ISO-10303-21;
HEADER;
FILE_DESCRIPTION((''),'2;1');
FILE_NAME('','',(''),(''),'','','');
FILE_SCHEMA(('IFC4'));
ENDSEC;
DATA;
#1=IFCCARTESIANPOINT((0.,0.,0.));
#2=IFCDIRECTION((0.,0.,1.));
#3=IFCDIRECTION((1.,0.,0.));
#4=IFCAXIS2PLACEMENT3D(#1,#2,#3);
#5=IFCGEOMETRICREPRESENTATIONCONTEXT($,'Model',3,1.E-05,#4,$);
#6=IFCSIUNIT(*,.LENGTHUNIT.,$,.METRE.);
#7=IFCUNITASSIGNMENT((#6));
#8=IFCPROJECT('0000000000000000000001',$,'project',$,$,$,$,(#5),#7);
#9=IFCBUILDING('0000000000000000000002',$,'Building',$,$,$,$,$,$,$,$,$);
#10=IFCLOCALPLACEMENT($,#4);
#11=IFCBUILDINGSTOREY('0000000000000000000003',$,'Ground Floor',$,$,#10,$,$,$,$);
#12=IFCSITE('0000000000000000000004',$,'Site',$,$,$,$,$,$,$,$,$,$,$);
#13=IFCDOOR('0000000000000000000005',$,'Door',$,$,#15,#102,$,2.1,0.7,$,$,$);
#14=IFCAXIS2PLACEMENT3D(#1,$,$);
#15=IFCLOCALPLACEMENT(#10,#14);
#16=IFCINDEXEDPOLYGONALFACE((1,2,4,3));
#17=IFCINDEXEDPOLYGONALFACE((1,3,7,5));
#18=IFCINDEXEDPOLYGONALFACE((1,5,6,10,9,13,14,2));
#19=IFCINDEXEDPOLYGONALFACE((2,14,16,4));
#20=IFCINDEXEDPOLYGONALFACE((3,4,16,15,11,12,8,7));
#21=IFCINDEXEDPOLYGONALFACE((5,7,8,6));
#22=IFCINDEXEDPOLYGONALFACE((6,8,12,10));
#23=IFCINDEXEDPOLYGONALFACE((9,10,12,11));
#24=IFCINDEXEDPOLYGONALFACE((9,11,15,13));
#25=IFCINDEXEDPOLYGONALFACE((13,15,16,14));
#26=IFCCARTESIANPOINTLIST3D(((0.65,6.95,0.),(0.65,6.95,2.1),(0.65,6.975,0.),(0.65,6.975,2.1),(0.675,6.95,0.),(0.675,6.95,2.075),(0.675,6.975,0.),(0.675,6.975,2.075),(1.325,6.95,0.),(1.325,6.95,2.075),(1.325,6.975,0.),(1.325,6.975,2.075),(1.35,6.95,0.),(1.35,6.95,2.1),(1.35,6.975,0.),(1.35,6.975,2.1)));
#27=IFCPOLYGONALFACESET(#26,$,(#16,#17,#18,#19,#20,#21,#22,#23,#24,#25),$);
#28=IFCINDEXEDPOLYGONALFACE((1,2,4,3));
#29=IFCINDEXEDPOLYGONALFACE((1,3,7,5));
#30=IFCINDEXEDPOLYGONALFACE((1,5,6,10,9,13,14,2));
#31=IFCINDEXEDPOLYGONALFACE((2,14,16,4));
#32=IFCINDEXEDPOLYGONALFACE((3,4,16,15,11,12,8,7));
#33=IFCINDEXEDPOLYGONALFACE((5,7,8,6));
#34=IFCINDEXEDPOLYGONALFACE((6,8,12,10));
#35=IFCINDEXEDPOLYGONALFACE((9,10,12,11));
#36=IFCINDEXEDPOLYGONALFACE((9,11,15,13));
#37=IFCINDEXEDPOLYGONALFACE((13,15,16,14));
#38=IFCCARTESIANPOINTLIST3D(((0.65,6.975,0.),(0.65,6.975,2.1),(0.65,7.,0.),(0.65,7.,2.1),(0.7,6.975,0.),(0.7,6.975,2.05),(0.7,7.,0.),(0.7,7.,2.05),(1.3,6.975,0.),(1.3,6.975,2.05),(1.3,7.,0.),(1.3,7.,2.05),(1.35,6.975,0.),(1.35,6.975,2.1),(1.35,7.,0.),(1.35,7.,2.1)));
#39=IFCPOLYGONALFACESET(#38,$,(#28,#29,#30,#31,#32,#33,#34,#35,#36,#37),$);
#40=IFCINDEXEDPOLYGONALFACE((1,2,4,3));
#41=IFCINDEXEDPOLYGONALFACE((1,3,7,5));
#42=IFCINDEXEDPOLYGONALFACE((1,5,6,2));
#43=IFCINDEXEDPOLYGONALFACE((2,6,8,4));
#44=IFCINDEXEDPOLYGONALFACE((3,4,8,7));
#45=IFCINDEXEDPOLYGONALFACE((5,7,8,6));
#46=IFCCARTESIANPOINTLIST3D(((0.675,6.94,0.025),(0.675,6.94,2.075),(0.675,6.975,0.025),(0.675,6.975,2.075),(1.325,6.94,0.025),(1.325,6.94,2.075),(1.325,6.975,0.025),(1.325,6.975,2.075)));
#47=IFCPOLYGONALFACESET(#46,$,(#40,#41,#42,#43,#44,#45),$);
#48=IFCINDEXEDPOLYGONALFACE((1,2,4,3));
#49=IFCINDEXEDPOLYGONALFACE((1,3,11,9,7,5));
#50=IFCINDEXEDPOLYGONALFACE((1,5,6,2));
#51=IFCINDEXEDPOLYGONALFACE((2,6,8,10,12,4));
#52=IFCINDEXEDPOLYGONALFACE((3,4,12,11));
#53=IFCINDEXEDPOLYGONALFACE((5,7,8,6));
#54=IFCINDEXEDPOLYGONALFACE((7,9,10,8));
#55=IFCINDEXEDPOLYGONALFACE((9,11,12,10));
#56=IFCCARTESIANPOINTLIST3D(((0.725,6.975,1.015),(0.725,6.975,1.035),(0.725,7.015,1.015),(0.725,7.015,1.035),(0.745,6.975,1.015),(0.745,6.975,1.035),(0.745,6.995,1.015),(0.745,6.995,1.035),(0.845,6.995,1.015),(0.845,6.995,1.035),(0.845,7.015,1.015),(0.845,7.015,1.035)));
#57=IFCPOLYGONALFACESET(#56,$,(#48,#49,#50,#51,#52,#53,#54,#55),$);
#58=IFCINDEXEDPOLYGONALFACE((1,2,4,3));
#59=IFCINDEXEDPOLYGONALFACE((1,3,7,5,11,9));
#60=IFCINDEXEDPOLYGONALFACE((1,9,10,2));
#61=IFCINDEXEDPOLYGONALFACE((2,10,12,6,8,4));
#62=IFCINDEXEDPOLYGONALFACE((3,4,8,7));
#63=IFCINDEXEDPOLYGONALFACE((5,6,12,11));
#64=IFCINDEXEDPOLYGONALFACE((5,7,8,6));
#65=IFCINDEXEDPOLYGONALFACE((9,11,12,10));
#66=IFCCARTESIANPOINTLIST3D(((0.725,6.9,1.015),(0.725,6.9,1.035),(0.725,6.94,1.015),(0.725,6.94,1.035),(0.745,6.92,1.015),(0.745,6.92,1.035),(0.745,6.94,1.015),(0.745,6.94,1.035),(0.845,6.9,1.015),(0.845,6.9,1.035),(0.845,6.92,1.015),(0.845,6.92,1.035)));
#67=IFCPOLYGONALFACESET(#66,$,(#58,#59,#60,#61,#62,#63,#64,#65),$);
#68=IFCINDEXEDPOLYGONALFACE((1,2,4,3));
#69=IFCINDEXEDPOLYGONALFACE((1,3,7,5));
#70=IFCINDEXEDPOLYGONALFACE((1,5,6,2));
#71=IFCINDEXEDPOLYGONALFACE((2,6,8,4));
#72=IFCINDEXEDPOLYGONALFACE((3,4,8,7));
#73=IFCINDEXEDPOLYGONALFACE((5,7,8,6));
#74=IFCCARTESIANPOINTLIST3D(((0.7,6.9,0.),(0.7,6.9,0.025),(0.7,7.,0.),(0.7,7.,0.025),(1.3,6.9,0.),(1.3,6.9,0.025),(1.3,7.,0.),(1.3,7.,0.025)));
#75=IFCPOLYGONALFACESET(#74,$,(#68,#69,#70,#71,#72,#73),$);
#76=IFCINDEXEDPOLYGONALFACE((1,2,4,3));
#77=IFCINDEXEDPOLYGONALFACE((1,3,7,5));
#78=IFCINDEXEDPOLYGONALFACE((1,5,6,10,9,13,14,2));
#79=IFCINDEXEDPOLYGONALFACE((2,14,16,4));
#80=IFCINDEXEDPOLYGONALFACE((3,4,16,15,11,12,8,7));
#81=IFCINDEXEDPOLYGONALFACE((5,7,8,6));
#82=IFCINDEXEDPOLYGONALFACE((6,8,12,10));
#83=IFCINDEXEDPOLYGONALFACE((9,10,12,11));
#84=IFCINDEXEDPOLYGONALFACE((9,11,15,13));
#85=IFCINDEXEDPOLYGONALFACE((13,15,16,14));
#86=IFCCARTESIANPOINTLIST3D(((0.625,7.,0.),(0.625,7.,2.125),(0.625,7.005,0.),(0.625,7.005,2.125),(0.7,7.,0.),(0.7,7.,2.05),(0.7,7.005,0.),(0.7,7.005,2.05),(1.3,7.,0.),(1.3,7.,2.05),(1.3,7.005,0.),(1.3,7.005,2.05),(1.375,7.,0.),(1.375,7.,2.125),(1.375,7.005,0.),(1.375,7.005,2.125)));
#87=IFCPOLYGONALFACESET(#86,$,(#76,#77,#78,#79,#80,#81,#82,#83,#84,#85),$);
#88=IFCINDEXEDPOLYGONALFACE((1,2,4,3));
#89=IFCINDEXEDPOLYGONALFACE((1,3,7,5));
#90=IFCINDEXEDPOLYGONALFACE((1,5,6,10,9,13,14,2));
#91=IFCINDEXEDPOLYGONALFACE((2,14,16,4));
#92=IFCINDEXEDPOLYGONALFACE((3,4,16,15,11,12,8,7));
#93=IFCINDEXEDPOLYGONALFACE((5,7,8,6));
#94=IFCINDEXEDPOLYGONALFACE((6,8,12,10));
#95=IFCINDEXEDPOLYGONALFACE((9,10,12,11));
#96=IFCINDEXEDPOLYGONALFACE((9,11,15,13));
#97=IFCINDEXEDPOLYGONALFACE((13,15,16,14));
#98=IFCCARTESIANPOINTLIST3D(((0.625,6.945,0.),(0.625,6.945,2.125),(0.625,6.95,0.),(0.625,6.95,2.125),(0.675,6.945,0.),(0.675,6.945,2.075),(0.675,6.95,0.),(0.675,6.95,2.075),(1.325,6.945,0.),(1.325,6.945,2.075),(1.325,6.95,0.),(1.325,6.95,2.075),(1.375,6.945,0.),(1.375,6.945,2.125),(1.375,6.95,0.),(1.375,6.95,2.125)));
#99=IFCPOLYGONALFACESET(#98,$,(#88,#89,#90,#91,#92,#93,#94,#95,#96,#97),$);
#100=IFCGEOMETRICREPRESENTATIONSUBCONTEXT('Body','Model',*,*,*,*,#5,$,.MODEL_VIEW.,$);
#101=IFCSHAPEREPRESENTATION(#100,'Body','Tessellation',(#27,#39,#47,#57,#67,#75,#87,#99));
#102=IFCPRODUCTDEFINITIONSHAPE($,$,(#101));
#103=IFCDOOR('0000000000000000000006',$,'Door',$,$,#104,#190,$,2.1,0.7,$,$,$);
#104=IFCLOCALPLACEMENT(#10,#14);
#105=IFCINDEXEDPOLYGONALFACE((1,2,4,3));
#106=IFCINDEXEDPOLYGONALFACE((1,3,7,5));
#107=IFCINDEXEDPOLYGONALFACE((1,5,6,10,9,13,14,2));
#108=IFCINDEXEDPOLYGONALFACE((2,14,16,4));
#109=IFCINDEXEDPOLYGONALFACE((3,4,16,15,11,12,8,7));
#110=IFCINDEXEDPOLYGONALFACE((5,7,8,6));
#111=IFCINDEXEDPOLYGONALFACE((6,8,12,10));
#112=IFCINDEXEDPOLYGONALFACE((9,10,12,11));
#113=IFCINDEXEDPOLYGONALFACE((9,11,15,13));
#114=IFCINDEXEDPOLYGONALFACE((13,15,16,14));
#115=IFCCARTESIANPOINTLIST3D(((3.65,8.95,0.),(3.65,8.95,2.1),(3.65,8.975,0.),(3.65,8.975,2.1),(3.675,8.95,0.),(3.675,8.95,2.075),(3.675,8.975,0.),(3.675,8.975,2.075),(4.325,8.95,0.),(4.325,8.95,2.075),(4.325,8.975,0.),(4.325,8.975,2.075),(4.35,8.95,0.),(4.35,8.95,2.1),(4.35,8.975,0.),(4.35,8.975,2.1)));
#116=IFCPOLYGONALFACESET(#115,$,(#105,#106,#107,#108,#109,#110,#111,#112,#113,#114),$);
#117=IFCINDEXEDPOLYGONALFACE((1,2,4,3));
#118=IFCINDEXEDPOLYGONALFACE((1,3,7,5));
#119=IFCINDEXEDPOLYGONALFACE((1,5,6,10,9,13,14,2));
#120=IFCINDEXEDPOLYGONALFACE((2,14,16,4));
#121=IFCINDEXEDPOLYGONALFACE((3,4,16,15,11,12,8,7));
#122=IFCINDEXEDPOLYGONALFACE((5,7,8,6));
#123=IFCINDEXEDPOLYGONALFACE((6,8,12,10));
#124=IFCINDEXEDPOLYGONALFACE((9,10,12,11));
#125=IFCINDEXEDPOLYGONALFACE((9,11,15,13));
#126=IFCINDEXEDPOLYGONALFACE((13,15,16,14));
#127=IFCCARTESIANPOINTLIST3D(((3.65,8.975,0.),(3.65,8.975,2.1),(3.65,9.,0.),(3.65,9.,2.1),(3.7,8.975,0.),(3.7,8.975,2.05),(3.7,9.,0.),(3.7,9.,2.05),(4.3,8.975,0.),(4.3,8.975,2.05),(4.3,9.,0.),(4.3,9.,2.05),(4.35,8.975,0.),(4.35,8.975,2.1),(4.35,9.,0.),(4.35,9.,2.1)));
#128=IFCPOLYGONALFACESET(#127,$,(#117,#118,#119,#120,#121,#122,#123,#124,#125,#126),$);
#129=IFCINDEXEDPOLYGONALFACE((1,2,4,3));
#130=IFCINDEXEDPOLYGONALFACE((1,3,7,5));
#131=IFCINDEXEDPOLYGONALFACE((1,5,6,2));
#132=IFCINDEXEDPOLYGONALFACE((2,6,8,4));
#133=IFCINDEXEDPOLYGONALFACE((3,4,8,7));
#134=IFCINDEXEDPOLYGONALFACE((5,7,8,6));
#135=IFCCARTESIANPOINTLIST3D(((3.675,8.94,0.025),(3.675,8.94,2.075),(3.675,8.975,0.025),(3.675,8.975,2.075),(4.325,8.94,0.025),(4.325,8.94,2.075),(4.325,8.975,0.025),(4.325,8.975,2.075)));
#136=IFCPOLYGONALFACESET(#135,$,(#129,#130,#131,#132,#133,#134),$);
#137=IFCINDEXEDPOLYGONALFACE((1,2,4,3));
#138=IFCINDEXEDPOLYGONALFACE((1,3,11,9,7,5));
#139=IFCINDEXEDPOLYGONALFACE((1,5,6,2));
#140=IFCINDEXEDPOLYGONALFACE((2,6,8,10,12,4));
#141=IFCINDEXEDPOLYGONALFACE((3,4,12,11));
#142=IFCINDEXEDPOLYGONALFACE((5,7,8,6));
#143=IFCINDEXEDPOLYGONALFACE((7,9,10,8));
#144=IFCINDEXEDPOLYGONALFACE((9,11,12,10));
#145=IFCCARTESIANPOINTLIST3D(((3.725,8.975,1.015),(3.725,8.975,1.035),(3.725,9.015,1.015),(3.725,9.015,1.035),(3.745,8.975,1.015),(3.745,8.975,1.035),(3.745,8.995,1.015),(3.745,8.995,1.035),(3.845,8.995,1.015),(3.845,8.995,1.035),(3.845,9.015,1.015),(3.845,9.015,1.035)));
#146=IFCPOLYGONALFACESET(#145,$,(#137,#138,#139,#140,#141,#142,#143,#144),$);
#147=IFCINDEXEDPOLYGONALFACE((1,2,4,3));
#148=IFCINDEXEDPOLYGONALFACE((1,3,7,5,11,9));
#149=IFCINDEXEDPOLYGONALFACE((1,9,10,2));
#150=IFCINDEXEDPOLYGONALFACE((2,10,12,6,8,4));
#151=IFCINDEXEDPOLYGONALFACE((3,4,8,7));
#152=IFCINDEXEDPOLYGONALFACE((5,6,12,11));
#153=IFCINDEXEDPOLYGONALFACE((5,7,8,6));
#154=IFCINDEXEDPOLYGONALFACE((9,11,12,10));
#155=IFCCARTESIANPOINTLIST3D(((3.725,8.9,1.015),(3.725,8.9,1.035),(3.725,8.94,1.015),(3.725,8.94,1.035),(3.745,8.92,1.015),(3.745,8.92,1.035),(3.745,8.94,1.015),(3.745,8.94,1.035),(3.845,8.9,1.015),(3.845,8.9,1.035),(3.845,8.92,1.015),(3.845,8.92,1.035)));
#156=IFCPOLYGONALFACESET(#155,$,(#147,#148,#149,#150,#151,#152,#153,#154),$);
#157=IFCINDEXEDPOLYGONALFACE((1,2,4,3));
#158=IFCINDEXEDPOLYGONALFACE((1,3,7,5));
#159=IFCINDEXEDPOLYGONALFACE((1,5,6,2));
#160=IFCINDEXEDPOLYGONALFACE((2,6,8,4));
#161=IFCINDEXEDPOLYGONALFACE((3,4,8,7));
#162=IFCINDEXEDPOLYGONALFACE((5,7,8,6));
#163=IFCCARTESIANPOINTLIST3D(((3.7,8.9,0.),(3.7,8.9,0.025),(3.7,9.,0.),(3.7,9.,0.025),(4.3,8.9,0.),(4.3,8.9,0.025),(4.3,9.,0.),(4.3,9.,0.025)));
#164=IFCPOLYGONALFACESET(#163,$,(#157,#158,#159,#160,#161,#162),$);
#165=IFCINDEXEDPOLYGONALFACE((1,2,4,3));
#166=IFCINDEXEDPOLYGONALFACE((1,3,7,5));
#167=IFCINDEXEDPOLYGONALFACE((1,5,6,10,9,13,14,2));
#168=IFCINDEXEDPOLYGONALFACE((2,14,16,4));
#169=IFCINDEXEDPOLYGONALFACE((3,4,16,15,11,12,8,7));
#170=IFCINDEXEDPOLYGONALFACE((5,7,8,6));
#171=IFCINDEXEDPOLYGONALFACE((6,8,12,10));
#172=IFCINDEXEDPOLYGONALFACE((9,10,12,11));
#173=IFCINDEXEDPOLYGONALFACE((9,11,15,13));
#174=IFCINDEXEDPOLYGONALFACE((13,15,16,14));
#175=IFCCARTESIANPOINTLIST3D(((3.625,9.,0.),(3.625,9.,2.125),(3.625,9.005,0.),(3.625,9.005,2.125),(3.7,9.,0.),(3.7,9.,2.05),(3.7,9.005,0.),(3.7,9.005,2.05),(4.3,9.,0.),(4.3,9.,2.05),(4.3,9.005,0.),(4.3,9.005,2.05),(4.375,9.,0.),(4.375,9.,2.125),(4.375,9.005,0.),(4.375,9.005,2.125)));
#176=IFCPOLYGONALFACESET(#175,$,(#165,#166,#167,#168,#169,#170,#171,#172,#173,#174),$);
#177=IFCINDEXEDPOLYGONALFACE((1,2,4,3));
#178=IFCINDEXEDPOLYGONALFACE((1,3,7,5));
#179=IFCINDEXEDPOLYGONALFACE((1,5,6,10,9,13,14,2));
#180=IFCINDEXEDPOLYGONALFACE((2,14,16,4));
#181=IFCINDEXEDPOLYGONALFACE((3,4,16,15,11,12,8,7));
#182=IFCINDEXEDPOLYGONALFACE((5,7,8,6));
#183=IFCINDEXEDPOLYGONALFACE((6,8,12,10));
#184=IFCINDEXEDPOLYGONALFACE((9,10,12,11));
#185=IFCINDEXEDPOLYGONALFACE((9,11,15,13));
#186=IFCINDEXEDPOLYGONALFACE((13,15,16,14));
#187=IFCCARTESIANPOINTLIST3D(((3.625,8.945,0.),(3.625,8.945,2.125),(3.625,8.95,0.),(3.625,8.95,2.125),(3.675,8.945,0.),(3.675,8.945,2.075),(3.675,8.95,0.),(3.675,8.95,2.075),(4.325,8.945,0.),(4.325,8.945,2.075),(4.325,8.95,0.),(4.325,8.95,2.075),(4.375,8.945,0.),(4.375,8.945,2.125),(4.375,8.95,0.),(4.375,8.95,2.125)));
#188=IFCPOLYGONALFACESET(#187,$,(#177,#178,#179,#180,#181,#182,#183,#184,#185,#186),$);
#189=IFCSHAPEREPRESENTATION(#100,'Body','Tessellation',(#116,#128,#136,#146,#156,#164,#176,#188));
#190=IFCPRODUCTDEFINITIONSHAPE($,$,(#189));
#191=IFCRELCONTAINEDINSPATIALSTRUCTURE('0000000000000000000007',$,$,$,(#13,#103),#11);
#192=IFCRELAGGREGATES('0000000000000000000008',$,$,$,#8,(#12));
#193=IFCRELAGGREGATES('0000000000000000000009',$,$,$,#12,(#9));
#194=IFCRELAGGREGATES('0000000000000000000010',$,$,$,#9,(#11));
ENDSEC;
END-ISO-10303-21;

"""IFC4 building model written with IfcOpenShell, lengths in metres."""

from ifc_helpers import new_model, si_unit, frame, origin_with_axes, place, context, subcontext, project, spatial, line, indexed_curve, outline, extrude, element, save


model = new_model("IFC4")

# Units and contexts
model_context = context("Model", 3, precision=1e-05, world=origin_with_axes())
body_context = subcontext(model_context, "Body", "Model", "MODEL_VIEW")
ifc_project = project(units=[si_unit("LENGTHUNIT", "METRE")], contexts=[model_context])

# Site, building, storey
site = spatial("IfcSite", under=ifc_project, Name="Site")
building = spatial("IfcBuilding", under=site, Name="Building")
storey_placement = place(None, origin_with_axes())
storey = spatial("IfcBuildingStorey", under=building, at=storey_placement, Name="Ground Floor")

# Doors
door_1_placement = place(storey_placement, frame((1.35, 7.0, 0.0), z_axis=(0.0, 0.0, 1.0), x_axis=(-1.0, 0.0, 0.0)))
element("IfcDoor", 1, at=door_1_placement, inside=storey, Name="Door", OverallHeight=2.1, OverallWidth=0.7, context=body_context, shape_type="SweptSolid", body=[
    extrude(outline(indexed_curve([(0.0, 0.0), (0.0, 2.1), (0.7, 2.1), (0.7, 0.0), (0.675, 0.0), (0.675, 2.075), (0.025, 2.075), (0.025, 0.0)], segments=[line(1, 2, 3, 4, 5, 6, 7, 8, 1)])), frame((0.0, 0.025, 0.0), z_axis=(0.0, -1.0, 0.0), x_axis=(1.0, 0.0, 0.0)), (0.0, 0.0, -1.0), 0.025),
    extrude(outline(indexed_curve([(0.0, 0.0), (0.0, 2.1), (0.7, 2.1), (0.7, 0.0), (0.65, 0.0), (0.65, 2.05), (0.05, 2.05), (0.05, 0.0)], segments=[line(1, 2, 3, 4, 5, 6, 7, 8, 1)])), frame((0.0, 0.0, 0.0), z_axis=(0.0, -1.0, 0.0), x_axis=(1.0, 0.0, 0.0)), (0.0, 0.0, -1.0), 0.025),
    extrude(outline(indexed_curve([(0.0, 0.0), (0.65, 0.0), (0.65, 0.035), (0.0, 0.035)], segments=[line(1, 2, 3, 4, 1)])), frame((0.025, 0.025, 0.025), z_axis=(0.0, 0.0, 1.0), x_axis=(1.0, 0.0, 0.0)), (0.0, 0.0, 1.0), 2.05),
    extrude(outline(indexed_curve([(0.0, 0.0), (0.0, -0.04), (-0.12, -0.04), (-0.12, -0.02), (-0.02, -0.02), (-0.02, 0.0)], segments=[line(1, 2, 3, 4, 5, 6, 1)])), frame((0.625, 0.025, 1.015), z_axis=(0.0, 0.0, 1.0), x_axis=(1.0, 0.0, 0.0)), (0.0, 0.0, 1.0), 0.02),
    extrude(outline(indexed_curve([(0.0, 0.0), (0.0, 0.04), (-0.12, 0.04), (-0.12, 0.02), (-0.02, 0.02), (-0.02, 0.0)], segments=[line(1, 2, 3, 4, 5, 6, 1)])), frame((0.625, 0.06, 1.015), z_axis=(0.0, 0.0, 1.0), x_axis=(1.0, 0.0, 0.0)), (0.0, 0.0, 1.0), 0.02),
    extrude(outline(indexed_curve([(0.0, 0.0), (0.6, 0.0), (0.6, 0.1), (0.0, 0.1)], segments=[line(1, 2, 3, 4, 1)])), frame((0.05, 0.0, 0.0), z_axis=(0.0, 0.0, 1.0), x_axis=(1.0, 0.0, 0.0)), (0.0, 0.0, 1.0), 0.025),
    extrude(outline(indexed_curve([(0.0, 0.0), (0.0, 2.125), (0.75, 2.125), (0.75, 0.0), (0.675, 0.0), (0.675, 2.05), (0.075, 2.05), (0.075, 0.0)], segments=[line(1, 2, 3, 4, 5, 6, 7, 8, 1)])), frame((-0.025, -0.005, 0.0), z_axis=(0.0, -1.0, 0.0), x_axis=(1.0, 0.0, 0.0)), (0.0, 0.0, -1.0), 0.005),
    extrude(outline(indexed_curve([(0.0, 0.0), (0.0, 2.125), (0.75, 2.125), (0.75, 0.0), (0.7, 0.0), (0.7, 2.075), (0.05, 2.075), (0.05, 0.0)], segments=[line(1, 2, 3, 4, 5, 6, 7, 8, 1)])), frame((-0.025, 0.05, 0.0), z_axis=(0.0, -1.0, 0.0), x_axis=(1.0, 0.0, 0.0)), (0.0, 0.0, -1.0), 0.005),
])
door_2_placement = place(storey_placement, frame((4.35, 9.0, 0.0), z_axis=(0.0, 0.0, 1.0), x_axis=(-1.0, 0.0, 0.0)))
element("IfcDoor", 2, at=door_2_placement, inside=storey, Name="Door", OverallHeight=2.1, OverallWidth=0.7, context=body_context, shape_type="SweptSolid", body=[
    extrude(outline(indexed_curve([(0.0, 0.0), (0.0, 2.1), (0.7, 2.1), (0.7, 0.0), (0.675, 0.0), (0.675, 2.075), (0.025, 2.075), (0.025, 0.0)], segments=[line(1, 2, 3, 4, 5, 6, 7, 8, 1)])), frame((0.0, 0.025, 0.0), z_axis=(0.0, -1.0, 0.0), x_axis=(1.0, 0.0, 0.0)), (0.0, 0.0, -1.0), 0.025),
    extrude(outline(indexed_curve([(0.0, 0.0), (0.0, 2.1), (0.7, 2.1), (0.7, 0.0), (0.65, 0.0), (0.65, 2.05), (0.05, 2.05), (0.05, 0.0)], segments=[line(1, 2, 3, 4, 5, 6, 7, 8, 1)])), frame((0.0, 0.0, 0.0), z_axis=(0.0, -1.0, 0.0), x_axis=(1.0, 0.0, 0.0)), (0.0, 0.0, -1.0), 0.025),
    extrude(outline(indexed_curve([(0.0, 0.0), (0.65, 0.0), (0.65, 0.035), (0.0, 0.035)], segments=[line(1, 2, 3, 4, 1)])), frame((0.025, 0.025, 0.025), z_axis=(0.0, 0.0, 1.0), x_axis=(1.0, 0.0, 0.0)), (0.0, 0.0, 1.0), 2.05),
    extrude(outline(indexed_curve([(0.0, 0.0), (0.0, -0.04), (-0.12, -0.04), (-0.12, -0.02), (-0.02, -0.02), (-0.02, 0.0)], segments=[line(1, 2, 3, 4, 5, 6, 1)])), frame((0.625, 0.025, 1.015), z_axis=(0.0, 0.0, 1.0), x_axis=(1.0, 0.0, 0.0)), (0.0, 0.0, 1.0), 0.02),
    extrude(outline(indexed_curve([(0.0, 0.0), (0.0, 0.04), (-0.12, 0.04), (-0.12, 0.02), (-0.02, 0.02), (-0.02, 0.0)], segments=[line(1, 2, 3, 4, 5, 6, 1)])), frame((0.625, 0.06, 1.015), z_axis=(0.0, 0.0, 1.0), x_axis=(1.0, 0.0, 0.0)), (0.0, 0.0, 1.0), 0.02),
    extrude(outline(indexed_curve([(0.0, 0.0), (0.6, 0.0), (0.6, 0.1), (0.0, 0.1)], segments=[line(1, 2, 3, 4, 1)])), frame((0.05, 0.0, 0.0), z_axis=(0.0, 0.0, 1.0), x_axis=(1.0, 0.0, 0.0)), (0.0, 0.0, 1.0), 0.025),
    extrude(outline(indexed_curve([(0.0, 0.0), (0.0, 2.125), (0.75, 2.125), (0.75, 0.0), (0.675, 0.0), (0.675, 2.05), (0.075, 2.05), (0.075, 0.0)], segments=[line(1, 2, 3, 4, 5, 6, 7, 8, 1)])), frame((-0.025, -0.005, 0.0), z_axis=(0.0, -1.0, 0.0), x_axis=(1.0, 0.0, 0.0)), (0.0, 0.0, -1.0), 0.005),
    extrude(outline(indexed_curve([(0.0, 0.0), (0.0, 2.125), (0.75, 2.125), (0.75, 0.0), (0.7, 0.0), (0.7, 2.075), (0.05, 2.075), (0.05, 0.0)], segments=[line(1, 2, 3, 4, 5, 6, 7, 8, 1)])), frame((-0.025, 0.05, 0.0), z_axis=(0.0, -1.0, 0.0), x_axis=(1.0, 0.0, 0.0)), (0.0, 0.0, -1.0), 0.005),
])

save(model, "model.ifc")
